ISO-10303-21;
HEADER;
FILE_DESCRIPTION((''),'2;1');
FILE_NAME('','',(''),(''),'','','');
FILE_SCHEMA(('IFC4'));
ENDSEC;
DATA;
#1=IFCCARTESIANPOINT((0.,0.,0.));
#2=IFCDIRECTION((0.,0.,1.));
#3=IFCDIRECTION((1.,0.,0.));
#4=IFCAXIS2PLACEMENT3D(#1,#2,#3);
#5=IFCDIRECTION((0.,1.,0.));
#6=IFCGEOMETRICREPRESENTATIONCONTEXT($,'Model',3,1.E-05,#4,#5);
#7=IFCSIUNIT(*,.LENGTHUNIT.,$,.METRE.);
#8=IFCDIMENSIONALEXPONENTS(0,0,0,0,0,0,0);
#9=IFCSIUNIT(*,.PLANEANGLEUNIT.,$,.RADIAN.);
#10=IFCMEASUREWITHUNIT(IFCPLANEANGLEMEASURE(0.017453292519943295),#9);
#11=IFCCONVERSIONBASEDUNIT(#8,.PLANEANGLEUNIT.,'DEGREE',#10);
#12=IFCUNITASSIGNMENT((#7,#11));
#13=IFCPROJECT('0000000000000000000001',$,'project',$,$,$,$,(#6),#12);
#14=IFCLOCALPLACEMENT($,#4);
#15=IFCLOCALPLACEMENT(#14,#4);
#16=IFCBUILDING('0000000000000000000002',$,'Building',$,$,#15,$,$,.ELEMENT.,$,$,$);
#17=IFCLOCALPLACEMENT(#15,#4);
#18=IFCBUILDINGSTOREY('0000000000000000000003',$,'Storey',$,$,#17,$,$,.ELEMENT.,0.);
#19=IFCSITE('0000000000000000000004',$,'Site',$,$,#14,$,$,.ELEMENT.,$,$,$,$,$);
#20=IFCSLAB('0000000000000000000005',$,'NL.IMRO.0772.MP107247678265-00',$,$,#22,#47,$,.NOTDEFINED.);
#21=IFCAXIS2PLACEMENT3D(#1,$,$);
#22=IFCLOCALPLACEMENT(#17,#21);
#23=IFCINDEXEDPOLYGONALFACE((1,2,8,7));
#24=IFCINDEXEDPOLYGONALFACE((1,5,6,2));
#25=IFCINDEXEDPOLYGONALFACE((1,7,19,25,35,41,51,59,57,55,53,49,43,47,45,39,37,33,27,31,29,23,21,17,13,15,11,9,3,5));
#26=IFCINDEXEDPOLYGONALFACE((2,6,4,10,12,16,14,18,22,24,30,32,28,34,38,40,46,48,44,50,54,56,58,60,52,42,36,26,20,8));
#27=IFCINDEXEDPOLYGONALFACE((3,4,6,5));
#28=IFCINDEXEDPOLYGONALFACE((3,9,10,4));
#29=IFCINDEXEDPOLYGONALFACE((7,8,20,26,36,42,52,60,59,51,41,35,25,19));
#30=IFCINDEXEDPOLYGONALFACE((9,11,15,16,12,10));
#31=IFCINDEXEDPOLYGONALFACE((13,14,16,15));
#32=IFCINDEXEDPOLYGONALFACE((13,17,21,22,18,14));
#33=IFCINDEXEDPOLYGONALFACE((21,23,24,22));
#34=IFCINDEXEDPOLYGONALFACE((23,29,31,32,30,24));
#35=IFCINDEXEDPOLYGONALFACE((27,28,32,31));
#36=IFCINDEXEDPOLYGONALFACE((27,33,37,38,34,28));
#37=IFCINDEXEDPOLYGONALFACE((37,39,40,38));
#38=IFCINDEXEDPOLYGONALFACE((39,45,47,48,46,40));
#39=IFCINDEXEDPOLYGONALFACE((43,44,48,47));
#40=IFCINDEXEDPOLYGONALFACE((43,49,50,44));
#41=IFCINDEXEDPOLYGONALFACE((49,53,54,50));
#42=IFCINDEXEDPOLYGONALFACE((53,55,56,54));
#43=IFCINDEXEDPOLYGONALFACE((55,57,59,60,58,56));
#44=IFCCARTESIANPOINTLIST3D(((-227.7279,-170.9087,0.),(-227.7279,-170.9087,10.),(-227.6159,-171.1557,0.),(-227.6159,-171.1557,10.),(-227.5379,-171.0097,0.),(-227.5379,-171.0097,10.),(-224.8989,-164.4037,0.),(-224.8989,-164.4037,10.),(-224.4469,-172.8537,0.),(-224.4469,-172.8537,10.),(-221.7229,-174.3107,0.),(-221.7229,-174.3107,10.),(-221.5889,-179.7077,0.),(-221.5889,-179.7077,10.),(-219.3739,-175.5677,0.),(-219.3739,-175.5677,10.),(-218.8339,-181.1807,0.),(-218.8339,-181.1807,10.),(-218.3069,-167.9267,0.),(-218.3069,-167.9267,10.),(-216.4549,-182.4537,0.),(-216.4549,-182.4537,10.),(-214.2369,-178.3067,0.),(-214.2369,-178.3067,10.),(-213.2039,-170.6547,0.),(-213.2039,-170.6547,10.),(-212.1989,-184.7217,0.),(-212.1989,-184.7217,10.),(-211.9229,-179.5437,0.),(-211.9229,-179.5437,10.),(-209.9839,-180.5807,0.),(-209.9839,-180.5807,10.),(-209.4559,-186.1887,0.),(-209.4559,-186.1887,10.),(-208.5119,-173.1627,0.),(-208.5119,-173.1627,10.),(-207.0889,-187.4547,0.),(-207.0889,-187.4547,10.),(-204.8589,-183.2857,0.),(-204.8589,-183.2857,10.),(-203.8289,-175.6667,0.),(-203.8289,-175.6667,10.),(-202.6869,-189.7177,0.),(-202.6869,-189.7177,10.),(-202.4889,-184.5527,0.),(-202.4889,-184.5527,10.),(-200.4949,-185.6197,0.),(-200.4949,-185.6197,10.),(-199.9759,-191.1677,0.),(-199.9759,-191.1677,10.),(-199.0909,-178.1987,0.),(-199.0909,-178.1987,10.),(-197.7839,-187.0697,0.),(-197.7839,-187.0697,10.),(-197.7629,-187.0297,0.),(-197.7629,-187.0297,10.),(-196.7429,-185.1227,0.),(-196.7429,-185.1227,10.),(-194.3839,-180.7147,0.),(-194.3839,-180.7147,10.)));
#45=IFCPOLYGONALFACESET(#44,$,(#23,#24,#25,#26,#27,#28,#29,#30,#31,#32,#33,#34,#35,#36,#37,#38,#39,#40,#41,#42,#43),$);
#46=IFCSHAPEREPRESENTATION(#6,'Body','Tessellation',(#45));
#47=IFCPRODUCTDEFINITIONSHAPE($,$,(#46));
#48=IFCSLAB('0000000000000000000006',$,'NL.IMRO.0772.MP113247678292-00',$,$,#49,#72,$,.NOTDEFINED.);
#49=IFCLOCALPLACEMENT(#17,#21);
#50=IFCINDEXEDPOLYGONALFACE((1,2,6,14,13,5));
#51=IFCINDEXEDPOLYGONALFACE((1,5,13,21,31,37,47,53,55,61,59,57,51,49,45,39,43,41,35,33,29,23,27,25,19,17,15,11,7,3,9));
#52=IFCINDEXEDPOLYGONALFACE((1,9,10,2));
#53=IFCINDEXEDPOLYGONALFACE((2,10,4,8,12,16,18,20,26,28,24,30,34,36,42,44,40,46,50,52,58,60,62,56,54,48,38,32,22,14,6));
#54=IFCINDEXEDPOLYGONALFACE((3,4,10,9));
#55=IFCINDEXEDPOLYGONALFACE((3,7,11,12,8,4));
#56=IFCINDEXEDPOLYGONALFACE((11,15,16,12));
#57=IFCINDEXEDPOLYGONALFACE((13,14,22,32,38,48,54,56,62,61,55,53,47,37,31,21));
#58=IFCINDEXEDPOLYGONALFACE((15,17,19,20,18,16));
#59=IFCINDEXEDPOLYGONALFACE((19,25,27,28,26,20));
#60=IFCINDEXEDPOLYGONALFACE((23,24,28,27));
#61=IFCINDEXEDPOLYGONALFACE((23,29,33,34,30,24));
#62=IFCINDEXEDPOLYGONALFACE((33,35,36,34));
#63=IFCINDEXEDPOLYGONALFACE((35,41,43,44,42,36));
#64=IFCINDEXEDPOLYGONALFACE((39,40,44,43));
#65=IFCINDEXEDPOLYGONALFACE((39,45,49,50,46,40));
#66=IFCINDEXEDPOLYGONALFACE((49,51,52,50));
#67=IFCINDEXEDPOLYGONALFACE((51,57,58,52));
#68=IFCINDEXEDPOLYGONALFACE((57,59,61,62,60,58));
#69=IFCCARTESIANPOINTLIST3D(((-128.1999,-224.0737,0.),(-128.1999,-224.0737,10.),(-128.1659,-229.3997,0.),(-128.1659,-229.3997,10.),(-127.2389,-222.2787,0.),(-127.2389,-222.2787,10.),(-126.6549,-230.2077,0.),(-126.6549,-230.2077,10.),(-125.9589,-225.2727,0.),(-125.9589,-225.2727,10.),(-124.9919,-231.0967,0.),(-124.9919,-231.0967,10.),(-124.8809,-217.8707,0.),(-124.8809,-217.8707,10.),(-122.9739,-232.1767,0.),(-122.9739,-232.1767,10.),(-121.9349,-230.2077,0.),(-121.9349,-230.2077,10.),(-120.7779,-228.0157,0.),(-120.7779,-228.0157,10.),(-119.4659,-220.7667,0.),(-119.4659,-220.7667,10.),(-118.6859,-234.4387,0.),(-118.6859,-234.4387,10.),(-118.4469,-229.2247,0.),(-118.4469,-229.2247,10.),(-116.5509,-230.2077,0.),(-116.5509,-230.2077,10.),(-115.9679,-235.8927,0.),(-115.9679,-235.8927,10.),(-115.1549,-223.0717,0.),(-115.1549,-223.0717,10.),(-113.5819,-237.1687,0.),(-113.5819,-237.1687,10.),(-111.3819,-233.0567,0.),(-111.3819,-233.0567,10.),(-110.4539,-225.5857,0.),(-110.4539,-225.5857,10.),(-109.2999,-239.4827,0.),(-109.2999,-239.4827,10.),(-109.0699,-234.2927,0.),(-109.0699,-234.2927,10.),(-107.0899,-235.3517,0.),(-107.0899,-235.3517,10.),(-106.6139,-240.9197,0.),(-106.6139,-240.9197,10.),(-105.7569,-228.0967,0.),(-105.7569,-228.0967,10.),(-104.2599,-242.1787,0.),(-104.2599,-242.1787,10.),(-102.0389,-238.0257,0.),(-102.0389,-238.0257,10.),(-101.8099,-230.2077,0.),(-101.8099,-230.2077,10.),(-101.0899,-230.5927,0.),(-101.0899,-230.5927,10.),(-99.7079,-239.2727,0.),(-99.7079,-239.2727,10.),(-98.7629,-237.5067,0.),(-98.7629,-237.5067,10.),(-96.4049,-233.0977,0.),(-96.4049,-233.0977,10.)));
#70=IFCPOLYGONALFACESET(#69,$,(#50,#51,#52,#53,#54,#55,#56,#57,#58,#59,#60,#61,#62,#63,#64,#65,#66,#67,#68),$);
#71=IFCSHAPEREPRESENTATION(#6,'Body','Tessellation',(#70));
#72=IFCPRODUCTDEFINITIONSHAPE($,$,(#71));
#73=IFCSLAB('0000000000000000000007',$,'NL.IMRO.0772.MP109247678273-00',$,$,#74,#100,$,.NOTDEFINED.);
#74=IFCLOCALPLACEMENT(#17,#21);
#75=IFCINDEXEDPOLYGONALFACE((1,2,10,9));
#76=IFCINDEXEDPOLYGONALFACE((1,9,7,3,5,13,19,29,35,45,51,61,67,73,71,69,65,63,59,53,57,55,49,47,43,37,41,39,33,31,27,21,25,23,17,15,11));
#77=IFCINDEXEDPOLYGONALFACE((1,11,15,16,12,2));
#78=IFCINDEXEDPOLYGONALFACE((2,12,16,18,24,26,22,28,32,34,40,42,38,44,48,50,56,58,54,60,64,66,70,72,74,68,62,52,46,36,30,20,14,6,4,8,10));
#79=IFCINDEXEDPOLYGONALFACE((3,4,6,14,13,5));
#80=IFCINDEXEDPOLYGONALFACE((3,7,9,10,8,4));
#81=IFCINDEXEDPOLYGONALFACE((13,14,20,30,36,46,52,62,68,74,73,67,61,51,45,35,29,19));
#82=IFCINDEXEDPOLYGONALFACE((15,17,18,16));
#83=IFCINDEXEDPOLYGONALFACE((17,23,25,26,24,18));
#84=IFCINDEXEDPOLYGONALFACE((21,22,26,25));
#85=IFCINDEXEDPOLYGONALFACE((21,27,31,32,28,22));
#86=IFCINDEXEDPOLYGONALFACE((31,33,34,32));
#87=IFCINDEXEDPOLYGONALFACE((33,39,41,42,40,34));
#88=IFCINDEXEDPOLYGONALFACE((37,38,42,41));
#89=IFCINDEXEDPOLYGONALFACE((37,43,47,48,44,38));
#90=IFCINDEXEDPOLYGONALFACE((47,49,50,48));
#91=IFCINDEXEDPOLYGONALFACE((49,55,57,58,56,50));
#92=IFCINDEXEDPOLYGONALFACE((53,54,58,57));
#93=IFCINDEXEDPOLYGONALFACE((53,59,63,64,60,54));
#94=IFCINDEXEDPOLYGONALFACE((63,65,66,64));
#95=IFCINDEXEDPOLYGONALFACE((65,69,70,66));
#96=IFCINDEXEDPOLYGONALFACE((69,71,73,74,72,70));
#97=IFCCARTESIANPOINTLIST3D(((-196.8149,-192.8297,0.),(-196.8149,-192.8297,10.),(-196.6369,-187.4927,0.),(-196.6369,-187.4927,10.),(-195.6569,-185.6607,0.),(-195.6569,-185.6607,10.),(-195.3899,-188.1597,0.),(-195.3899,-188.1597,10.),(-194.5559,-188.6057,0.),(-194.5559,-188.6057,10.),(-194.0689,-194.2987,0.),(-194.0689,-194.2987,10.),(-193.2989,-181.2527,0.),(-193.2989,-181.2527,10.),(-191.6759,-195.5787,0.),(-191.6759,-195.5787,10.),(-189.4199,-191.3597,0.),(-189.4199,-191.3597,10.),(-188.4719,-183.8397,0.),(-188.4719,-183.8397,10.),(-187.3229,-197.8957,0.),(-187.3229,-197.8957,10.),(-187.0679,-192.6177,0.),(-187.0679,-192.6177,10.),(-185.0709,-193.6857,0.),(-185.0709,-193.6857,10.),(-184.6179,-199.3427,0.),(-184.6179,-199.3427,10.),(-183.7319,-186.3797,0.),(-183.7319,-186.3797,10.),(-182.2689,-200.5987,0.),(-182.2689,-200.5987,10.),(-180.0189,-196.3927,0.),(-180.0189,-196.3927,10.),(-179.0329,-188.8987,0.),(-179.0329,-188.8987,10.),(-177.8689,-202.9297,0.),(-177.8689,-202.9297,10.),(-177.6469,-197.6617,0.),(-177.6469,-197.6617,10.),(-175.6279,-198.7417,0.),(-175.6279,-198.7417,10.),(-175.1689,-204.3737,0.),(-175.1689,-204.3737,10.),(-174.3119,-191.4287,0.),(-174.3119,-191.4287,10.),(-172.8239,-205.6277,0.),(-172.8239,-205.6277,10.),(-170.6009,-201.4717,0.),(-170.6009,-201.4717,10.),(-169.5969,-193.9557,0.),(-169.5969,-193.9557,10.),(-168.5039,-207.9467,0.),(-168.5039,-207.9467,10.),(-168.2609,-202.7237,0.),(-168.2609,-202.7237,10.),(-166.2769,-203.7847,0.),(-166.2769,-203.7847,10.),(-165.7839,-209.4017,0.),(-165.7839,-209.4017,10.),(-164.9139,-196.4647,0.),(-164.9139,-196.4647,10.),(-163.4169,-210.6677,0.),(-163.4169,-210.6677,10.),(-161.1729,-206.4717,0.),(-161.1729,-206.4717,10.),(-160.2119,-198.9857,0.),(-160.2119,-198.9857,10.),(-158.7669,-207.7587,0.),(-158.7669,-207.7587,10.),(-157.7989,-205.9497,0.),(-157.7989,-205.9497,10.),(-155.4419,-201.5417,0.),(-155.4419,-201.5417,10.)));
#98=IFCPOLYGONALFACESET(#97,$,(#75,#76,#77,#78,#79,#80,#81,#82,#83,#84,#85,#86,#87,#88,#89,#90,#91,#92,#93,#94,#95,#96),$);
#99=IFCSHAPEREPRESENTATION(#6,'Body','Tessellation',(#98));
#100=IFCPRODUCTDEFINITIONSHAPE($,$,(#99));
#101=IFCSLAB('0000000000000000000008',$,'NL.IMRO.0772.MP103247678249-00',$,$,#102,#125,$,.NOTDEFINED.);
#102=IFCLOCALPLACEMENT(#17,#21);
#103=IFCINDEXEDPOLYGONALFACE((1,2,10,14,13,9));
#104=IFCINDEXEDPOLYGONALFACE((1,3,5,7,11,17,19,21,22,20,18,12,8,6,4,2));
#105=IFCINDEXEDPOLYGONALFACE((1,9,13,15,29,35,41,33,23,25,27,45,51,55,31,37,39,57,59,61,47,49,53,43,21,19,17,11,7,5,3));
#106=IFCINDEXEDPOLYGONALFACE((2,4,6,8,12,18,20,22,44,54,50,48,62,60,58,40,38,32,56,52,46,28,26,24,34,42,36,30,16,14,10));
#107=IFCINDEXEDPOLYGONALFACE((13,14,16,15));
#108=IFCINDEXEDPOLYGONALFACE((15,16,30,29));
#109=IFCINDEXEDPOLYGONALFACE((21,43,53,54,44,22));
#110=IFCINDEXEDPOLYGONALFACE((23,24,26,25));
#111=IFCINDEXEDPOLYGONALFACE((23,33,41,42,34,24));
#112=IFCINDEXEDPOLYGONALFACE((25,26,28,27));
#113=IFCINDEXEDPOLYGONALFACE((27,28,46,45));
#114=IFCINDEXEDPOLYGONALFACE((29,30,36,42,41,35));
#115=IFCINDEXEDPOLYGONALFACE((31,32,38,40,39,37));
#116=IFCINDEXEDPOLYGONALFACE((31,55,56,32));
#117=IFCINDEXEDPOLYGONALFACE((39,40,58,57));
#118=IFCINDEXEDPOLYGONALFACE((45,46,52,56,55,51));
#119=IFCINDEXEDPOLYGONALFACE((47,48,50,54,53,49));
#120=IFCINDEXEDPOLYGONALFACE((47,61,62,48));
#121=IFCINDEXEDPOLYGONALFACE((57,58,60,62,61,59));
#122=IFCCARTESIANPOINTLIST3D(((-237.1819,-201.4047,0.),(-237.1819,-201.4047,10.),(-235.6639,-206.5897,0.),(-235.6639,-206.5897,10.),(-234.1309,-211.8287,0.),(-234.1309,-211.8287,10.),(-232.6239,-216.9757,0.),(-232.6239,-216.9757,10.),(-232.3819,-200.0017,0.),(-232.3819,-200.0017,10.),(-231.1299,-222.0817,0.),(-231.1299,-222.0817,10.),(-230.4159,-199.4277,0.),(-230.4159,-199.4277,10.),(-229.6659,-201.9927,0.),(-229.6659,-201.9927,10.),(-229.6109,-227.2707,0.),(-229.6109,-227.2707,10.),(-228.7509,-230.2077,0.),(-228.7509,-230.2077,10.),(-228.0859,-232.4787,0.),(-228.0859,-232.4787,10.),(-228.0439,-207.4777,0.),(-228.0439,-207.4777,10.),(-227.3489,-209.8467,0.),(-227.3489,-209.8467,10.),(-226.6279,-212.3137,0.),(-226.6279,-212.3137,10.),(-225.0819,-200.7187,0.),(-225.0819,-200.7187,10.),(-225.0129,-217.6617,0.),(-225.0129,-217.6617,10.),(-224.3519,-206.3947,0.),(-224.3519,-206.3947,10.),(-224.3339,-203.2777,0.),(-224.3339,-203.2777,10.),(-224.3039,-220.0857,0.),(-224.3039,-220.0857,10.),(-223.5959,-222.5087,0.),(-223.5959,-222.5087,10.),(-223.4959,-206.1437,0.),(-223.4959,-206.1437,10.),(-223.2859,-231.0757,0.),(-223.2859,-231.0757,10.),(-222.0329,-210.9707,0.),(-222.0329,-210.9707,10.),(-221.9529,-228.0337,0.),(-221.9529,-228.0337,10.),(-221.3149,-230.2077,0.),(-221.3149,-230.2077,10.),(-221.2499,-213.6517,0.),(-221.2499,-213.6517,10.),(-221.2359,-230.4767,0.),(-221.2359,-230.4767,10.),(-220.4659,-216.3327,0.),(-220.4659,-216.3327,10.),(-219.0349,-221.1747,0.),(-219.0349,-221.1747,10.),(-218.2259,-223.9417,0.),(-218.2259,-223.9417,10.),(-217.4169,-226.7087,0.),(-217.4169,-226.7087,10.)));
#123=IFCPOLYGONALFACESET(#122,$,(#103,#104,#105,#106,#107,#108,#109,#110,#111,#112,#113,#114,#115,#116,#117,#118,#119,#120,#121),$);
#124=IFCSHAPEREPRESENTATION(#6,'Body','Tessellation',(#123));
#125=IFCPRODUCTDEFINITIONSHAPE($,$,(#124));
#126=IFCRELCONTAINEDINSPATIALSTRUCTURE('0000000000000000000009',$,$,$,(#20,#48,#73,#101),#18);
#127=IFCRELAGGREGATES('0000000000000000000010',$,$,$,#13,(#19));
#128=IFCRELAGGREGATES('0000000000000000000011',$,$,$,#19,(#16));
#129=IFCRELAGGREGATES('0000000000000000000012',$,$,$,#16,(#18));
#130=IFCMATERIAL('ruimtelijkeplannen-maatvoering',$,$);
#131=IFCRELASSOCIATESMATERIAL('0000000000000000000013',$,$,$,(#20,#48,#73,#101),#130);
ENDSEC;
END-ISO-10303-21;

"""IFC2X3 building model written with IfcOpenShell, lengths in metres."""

from ifc_helpers import new_model, entity, si_unit, converted_unit, direction, origin_with_axes, place, context, project, spatial, polyline, outline, extrude, material, element, save


model = new_model("IFC2X3")

# Units and contexts
model_context = context("Model", 3, precision=1e-05, world=origin_with_axes(), true_north=direction((0.0, 1.0, 0.0)))
ifc_project = project(units=[si_unit("LENGTHUNIT", "METRE"), converted_unit("PLANEANGLEUNIT", "DEGREE", entity("IfcPlaneAngleMeasure", 0.017453292519943295), si_unit("PLANEANGLEUNIT", "RADIAN"), dimensions=[0, 0, 0, 0, 0, 0, 0])], contexts=[model_context])

# Site, building, storey
site_placement = place(None, origin_with_axes())
site = spatial("IfcSite", under=ifc_project, at=site_placement, Name="Site", CompositionType="ELEMENT")
building_placement = place(site_placement, origin_with_axes())
building = spatial("IfcBuilding", under=site, at=building_placement, Name="Building", CompositionType="ELEMENT")
storey_placement = place(building_placement, origin_with_axes())
storey = spatial("IfcBuildingStorey", under=building, at=storey_placement, Name="Storey", CompositionType="ELEMENT", Elevation=0.0)

# Slabs
ifc_material = material(Name="ruimtelijkeplannen-maatvoering")
slab_1_placement = place(storey_placement, origin_with_axes())
element("IfcSlab", 1, at=slab_1_placement, inside=storey, material=ifc_material, Name="NL.IMRO.0772.MP107247678265-00", PredefinedType="NOTDEFINED", context=model_context, shape_type="SweptSolid", body=[
    extrude(outline(polyline([(-227.5379, -171.0097), (-227.7279, -170.9087), (-224.8989, -164.4037), (-218.3069, -167.9267), (-213.2039, -170.6547), (-208.5119, -173.1627), (-203.8289, -175.6667), (-199.0909, -178.1987), (-194.3839, -180.7147), (-196.7429, -185.1227), (-197.7629, -187.0297), (-197.7839, -187.0697), (-199.9759, -191.1677), (-202.6869, -189.7177), (-200.4949, -185.6197), (-202.4889, -184.5527), (-204.8589, -183.2857), (-207.0889, -187.4547), (-209.4559, -186.1887), (-212.1989, -184.7217), (-209.9839, -180.5807), (-211.9229, -179.5437), (-214.2369, -178.3067), (-216.4549, -182.4537), (-218.8339, -181.1807), (-221.5889, -179.7077), (-219.3739, -175.5677), (-221.7229, -174.3107), (-224.4469, -172.8537), (-227.6159, -171.1557), (-227.5379, -171.0097)])), origin_with_axes(), (0.0, 0.0, 1.0), 10.0),
])
slab_2_placement = place(storey_placement, origin_with_axes())
element("IfcSlab", 2, at=slab_2_placement, inside=storey, material=ifc_material, Name="NL.IMRO.0772.MP113247678292-00", PredefinedType="NOTDEFINED", context=model_context, shape_type="SweptSolid", body=[
    extrude(outline(polyline([(-96.4049, -233.0977), (-98.7629, -237.5067), (-99.7079, -239.2727), (-102.0389, -238.0257), (-104.2599, -242.1787), (-106.6139, -240.9197), (-109.2999, -239.4827), (-107.0899, -235.3517), (-109.0699, -234.2927), (-111.3819, -233.0567), (-113.5819, -237.1687), (-115.9679, -235.8927), (-118.6859, -234.4387), (-116.5509, -230.2077), (-118.4469, -229.2247), (-120.7779, -228.0157), (-121.9349, -230.2077), (-122.9739, -232.1767), (-124.9919, -231.0967), (-126.6549, -230.2077), (-128.1659, -229.3997), (-125.9589, -225.2727), (-128.1999, -224.0737), (-127.2389, -222.2787), (-124.8809, -217.8707), (-119.4659, -220.7667), (-115.1549, -223.0717), (-110.4539, -225.5857), (-105.7569, -228.0967), (-101.8099, -230.2077), (-101.0899, -230.5927), (-96.4049, -233.0977)])), origin_with_axes(), (0.0, 0.0, 1.0), 10.0),
])
slab_3_placement = place(storey_placement, origin_with_axes())
element("IfcSlab", 3, at=slab_3_placement, inside=storey, material=ifc_material, Name="NL.IMRO.0772.MP109247678273-00", PredefinedType="NOTDEFINED", context=model_context, shape_type="SweptSolid", body=[
    extrude(outline(polyline([(-157.7989, -205.9497), (-158.7669, -207.7587), (-161.1729, -206.4717), (-163.4169, -210.6677), (-165.7839, -209.4017), (-168.5039, -207.9467), (-166.2769, -203.7847), (-168.2609, -202.7237), (-170.6009, -201.4717), (-172.8239, -205.6277), (-175.1689, -204.3737), (-177.8689, -202.9297), (-175.6279, -198.7417), (-177.6469, -197.6617), (-180.0189, -196.3927), (-182.2689, -200.5987), (-184.6179, -199.3427), (-187.3229, -197.8957), (-185.0709, -193.6857), (-187.0679, -192.6177), (-189.4199, -191.3597), (-191.6759, -195.5787), (-194.0689, -194.2987), (-196.8149, -192.8297), (-194.5559, -188.6057), (-195.3899, -188.1597), (-196.6369, -187.4927), (-195.6569, -185.6607), (-193.2989, -181.2527), (-188.4719, -183.8397), (-183.7319, -186.3797), (-179.0329, -188.8987), (-174.3119, -191.4287), (-169.5969, -193.9557), (-164.9139, -196.4647), (-160.2119, -198.9857), (-155.4419, -201.5417), (-157.7989, -205.9497)])), origin_with_axes(), (0.0, 0.0, 1.0), 10.0),
])
slab_4_placement = place(storey_placement, origin_with_axes())
element("IfcSlab", 4, at=slab_4_placement, inside=storey, material=ifc_material, Name="NL.IMRO.0772.MP103247678249-00", PredefinedType="NOTDEFINED", context=model_context, shape_type="SweptSolid", body=[
    extrude(outline(polyline([(-221.2359, -230.4767), (-223.2859, -231.0757), (-228.0859, -232.4787), (-228.7509, -230.2077), (-229.6109, -227.2707), (-231.1299, -222.0817), (-232.6239, -216.9757), (-234.1309, -211.8287), (-235.6639, -206.5897), (-237.1819, -201.4047), (-232.3819, -200.0017), (-230.4159, -199.4277), (-229.6659, -201.9927), (-225.0819, -200.7187), (-224.3339, -203.2777), (-223.4959, -206.1437), (-224.3519, -206.3947), (-228.0439, -207.4777), (-227.3489, -209.8467), (-226.6279, -212.3137), (-222.0329, -210.9707), (-221.2499, -213.6517), (-220.4659, -216.3327), (-225.0129, -217.6617), (-224.3039, -220.0857), (-223.5959, -222.5087), (-219.0349, -221.1747), (-218.2259, -223.9417), (-217.4169, -226.7087), (-221.9529, -228.0337), (-221.3149, -230.2077), (-221.2359, -230.4767)])), origin_with_axes(), (0.0, 0.0, 1.0), 10.0),
])

save(model, "model.ifc")
